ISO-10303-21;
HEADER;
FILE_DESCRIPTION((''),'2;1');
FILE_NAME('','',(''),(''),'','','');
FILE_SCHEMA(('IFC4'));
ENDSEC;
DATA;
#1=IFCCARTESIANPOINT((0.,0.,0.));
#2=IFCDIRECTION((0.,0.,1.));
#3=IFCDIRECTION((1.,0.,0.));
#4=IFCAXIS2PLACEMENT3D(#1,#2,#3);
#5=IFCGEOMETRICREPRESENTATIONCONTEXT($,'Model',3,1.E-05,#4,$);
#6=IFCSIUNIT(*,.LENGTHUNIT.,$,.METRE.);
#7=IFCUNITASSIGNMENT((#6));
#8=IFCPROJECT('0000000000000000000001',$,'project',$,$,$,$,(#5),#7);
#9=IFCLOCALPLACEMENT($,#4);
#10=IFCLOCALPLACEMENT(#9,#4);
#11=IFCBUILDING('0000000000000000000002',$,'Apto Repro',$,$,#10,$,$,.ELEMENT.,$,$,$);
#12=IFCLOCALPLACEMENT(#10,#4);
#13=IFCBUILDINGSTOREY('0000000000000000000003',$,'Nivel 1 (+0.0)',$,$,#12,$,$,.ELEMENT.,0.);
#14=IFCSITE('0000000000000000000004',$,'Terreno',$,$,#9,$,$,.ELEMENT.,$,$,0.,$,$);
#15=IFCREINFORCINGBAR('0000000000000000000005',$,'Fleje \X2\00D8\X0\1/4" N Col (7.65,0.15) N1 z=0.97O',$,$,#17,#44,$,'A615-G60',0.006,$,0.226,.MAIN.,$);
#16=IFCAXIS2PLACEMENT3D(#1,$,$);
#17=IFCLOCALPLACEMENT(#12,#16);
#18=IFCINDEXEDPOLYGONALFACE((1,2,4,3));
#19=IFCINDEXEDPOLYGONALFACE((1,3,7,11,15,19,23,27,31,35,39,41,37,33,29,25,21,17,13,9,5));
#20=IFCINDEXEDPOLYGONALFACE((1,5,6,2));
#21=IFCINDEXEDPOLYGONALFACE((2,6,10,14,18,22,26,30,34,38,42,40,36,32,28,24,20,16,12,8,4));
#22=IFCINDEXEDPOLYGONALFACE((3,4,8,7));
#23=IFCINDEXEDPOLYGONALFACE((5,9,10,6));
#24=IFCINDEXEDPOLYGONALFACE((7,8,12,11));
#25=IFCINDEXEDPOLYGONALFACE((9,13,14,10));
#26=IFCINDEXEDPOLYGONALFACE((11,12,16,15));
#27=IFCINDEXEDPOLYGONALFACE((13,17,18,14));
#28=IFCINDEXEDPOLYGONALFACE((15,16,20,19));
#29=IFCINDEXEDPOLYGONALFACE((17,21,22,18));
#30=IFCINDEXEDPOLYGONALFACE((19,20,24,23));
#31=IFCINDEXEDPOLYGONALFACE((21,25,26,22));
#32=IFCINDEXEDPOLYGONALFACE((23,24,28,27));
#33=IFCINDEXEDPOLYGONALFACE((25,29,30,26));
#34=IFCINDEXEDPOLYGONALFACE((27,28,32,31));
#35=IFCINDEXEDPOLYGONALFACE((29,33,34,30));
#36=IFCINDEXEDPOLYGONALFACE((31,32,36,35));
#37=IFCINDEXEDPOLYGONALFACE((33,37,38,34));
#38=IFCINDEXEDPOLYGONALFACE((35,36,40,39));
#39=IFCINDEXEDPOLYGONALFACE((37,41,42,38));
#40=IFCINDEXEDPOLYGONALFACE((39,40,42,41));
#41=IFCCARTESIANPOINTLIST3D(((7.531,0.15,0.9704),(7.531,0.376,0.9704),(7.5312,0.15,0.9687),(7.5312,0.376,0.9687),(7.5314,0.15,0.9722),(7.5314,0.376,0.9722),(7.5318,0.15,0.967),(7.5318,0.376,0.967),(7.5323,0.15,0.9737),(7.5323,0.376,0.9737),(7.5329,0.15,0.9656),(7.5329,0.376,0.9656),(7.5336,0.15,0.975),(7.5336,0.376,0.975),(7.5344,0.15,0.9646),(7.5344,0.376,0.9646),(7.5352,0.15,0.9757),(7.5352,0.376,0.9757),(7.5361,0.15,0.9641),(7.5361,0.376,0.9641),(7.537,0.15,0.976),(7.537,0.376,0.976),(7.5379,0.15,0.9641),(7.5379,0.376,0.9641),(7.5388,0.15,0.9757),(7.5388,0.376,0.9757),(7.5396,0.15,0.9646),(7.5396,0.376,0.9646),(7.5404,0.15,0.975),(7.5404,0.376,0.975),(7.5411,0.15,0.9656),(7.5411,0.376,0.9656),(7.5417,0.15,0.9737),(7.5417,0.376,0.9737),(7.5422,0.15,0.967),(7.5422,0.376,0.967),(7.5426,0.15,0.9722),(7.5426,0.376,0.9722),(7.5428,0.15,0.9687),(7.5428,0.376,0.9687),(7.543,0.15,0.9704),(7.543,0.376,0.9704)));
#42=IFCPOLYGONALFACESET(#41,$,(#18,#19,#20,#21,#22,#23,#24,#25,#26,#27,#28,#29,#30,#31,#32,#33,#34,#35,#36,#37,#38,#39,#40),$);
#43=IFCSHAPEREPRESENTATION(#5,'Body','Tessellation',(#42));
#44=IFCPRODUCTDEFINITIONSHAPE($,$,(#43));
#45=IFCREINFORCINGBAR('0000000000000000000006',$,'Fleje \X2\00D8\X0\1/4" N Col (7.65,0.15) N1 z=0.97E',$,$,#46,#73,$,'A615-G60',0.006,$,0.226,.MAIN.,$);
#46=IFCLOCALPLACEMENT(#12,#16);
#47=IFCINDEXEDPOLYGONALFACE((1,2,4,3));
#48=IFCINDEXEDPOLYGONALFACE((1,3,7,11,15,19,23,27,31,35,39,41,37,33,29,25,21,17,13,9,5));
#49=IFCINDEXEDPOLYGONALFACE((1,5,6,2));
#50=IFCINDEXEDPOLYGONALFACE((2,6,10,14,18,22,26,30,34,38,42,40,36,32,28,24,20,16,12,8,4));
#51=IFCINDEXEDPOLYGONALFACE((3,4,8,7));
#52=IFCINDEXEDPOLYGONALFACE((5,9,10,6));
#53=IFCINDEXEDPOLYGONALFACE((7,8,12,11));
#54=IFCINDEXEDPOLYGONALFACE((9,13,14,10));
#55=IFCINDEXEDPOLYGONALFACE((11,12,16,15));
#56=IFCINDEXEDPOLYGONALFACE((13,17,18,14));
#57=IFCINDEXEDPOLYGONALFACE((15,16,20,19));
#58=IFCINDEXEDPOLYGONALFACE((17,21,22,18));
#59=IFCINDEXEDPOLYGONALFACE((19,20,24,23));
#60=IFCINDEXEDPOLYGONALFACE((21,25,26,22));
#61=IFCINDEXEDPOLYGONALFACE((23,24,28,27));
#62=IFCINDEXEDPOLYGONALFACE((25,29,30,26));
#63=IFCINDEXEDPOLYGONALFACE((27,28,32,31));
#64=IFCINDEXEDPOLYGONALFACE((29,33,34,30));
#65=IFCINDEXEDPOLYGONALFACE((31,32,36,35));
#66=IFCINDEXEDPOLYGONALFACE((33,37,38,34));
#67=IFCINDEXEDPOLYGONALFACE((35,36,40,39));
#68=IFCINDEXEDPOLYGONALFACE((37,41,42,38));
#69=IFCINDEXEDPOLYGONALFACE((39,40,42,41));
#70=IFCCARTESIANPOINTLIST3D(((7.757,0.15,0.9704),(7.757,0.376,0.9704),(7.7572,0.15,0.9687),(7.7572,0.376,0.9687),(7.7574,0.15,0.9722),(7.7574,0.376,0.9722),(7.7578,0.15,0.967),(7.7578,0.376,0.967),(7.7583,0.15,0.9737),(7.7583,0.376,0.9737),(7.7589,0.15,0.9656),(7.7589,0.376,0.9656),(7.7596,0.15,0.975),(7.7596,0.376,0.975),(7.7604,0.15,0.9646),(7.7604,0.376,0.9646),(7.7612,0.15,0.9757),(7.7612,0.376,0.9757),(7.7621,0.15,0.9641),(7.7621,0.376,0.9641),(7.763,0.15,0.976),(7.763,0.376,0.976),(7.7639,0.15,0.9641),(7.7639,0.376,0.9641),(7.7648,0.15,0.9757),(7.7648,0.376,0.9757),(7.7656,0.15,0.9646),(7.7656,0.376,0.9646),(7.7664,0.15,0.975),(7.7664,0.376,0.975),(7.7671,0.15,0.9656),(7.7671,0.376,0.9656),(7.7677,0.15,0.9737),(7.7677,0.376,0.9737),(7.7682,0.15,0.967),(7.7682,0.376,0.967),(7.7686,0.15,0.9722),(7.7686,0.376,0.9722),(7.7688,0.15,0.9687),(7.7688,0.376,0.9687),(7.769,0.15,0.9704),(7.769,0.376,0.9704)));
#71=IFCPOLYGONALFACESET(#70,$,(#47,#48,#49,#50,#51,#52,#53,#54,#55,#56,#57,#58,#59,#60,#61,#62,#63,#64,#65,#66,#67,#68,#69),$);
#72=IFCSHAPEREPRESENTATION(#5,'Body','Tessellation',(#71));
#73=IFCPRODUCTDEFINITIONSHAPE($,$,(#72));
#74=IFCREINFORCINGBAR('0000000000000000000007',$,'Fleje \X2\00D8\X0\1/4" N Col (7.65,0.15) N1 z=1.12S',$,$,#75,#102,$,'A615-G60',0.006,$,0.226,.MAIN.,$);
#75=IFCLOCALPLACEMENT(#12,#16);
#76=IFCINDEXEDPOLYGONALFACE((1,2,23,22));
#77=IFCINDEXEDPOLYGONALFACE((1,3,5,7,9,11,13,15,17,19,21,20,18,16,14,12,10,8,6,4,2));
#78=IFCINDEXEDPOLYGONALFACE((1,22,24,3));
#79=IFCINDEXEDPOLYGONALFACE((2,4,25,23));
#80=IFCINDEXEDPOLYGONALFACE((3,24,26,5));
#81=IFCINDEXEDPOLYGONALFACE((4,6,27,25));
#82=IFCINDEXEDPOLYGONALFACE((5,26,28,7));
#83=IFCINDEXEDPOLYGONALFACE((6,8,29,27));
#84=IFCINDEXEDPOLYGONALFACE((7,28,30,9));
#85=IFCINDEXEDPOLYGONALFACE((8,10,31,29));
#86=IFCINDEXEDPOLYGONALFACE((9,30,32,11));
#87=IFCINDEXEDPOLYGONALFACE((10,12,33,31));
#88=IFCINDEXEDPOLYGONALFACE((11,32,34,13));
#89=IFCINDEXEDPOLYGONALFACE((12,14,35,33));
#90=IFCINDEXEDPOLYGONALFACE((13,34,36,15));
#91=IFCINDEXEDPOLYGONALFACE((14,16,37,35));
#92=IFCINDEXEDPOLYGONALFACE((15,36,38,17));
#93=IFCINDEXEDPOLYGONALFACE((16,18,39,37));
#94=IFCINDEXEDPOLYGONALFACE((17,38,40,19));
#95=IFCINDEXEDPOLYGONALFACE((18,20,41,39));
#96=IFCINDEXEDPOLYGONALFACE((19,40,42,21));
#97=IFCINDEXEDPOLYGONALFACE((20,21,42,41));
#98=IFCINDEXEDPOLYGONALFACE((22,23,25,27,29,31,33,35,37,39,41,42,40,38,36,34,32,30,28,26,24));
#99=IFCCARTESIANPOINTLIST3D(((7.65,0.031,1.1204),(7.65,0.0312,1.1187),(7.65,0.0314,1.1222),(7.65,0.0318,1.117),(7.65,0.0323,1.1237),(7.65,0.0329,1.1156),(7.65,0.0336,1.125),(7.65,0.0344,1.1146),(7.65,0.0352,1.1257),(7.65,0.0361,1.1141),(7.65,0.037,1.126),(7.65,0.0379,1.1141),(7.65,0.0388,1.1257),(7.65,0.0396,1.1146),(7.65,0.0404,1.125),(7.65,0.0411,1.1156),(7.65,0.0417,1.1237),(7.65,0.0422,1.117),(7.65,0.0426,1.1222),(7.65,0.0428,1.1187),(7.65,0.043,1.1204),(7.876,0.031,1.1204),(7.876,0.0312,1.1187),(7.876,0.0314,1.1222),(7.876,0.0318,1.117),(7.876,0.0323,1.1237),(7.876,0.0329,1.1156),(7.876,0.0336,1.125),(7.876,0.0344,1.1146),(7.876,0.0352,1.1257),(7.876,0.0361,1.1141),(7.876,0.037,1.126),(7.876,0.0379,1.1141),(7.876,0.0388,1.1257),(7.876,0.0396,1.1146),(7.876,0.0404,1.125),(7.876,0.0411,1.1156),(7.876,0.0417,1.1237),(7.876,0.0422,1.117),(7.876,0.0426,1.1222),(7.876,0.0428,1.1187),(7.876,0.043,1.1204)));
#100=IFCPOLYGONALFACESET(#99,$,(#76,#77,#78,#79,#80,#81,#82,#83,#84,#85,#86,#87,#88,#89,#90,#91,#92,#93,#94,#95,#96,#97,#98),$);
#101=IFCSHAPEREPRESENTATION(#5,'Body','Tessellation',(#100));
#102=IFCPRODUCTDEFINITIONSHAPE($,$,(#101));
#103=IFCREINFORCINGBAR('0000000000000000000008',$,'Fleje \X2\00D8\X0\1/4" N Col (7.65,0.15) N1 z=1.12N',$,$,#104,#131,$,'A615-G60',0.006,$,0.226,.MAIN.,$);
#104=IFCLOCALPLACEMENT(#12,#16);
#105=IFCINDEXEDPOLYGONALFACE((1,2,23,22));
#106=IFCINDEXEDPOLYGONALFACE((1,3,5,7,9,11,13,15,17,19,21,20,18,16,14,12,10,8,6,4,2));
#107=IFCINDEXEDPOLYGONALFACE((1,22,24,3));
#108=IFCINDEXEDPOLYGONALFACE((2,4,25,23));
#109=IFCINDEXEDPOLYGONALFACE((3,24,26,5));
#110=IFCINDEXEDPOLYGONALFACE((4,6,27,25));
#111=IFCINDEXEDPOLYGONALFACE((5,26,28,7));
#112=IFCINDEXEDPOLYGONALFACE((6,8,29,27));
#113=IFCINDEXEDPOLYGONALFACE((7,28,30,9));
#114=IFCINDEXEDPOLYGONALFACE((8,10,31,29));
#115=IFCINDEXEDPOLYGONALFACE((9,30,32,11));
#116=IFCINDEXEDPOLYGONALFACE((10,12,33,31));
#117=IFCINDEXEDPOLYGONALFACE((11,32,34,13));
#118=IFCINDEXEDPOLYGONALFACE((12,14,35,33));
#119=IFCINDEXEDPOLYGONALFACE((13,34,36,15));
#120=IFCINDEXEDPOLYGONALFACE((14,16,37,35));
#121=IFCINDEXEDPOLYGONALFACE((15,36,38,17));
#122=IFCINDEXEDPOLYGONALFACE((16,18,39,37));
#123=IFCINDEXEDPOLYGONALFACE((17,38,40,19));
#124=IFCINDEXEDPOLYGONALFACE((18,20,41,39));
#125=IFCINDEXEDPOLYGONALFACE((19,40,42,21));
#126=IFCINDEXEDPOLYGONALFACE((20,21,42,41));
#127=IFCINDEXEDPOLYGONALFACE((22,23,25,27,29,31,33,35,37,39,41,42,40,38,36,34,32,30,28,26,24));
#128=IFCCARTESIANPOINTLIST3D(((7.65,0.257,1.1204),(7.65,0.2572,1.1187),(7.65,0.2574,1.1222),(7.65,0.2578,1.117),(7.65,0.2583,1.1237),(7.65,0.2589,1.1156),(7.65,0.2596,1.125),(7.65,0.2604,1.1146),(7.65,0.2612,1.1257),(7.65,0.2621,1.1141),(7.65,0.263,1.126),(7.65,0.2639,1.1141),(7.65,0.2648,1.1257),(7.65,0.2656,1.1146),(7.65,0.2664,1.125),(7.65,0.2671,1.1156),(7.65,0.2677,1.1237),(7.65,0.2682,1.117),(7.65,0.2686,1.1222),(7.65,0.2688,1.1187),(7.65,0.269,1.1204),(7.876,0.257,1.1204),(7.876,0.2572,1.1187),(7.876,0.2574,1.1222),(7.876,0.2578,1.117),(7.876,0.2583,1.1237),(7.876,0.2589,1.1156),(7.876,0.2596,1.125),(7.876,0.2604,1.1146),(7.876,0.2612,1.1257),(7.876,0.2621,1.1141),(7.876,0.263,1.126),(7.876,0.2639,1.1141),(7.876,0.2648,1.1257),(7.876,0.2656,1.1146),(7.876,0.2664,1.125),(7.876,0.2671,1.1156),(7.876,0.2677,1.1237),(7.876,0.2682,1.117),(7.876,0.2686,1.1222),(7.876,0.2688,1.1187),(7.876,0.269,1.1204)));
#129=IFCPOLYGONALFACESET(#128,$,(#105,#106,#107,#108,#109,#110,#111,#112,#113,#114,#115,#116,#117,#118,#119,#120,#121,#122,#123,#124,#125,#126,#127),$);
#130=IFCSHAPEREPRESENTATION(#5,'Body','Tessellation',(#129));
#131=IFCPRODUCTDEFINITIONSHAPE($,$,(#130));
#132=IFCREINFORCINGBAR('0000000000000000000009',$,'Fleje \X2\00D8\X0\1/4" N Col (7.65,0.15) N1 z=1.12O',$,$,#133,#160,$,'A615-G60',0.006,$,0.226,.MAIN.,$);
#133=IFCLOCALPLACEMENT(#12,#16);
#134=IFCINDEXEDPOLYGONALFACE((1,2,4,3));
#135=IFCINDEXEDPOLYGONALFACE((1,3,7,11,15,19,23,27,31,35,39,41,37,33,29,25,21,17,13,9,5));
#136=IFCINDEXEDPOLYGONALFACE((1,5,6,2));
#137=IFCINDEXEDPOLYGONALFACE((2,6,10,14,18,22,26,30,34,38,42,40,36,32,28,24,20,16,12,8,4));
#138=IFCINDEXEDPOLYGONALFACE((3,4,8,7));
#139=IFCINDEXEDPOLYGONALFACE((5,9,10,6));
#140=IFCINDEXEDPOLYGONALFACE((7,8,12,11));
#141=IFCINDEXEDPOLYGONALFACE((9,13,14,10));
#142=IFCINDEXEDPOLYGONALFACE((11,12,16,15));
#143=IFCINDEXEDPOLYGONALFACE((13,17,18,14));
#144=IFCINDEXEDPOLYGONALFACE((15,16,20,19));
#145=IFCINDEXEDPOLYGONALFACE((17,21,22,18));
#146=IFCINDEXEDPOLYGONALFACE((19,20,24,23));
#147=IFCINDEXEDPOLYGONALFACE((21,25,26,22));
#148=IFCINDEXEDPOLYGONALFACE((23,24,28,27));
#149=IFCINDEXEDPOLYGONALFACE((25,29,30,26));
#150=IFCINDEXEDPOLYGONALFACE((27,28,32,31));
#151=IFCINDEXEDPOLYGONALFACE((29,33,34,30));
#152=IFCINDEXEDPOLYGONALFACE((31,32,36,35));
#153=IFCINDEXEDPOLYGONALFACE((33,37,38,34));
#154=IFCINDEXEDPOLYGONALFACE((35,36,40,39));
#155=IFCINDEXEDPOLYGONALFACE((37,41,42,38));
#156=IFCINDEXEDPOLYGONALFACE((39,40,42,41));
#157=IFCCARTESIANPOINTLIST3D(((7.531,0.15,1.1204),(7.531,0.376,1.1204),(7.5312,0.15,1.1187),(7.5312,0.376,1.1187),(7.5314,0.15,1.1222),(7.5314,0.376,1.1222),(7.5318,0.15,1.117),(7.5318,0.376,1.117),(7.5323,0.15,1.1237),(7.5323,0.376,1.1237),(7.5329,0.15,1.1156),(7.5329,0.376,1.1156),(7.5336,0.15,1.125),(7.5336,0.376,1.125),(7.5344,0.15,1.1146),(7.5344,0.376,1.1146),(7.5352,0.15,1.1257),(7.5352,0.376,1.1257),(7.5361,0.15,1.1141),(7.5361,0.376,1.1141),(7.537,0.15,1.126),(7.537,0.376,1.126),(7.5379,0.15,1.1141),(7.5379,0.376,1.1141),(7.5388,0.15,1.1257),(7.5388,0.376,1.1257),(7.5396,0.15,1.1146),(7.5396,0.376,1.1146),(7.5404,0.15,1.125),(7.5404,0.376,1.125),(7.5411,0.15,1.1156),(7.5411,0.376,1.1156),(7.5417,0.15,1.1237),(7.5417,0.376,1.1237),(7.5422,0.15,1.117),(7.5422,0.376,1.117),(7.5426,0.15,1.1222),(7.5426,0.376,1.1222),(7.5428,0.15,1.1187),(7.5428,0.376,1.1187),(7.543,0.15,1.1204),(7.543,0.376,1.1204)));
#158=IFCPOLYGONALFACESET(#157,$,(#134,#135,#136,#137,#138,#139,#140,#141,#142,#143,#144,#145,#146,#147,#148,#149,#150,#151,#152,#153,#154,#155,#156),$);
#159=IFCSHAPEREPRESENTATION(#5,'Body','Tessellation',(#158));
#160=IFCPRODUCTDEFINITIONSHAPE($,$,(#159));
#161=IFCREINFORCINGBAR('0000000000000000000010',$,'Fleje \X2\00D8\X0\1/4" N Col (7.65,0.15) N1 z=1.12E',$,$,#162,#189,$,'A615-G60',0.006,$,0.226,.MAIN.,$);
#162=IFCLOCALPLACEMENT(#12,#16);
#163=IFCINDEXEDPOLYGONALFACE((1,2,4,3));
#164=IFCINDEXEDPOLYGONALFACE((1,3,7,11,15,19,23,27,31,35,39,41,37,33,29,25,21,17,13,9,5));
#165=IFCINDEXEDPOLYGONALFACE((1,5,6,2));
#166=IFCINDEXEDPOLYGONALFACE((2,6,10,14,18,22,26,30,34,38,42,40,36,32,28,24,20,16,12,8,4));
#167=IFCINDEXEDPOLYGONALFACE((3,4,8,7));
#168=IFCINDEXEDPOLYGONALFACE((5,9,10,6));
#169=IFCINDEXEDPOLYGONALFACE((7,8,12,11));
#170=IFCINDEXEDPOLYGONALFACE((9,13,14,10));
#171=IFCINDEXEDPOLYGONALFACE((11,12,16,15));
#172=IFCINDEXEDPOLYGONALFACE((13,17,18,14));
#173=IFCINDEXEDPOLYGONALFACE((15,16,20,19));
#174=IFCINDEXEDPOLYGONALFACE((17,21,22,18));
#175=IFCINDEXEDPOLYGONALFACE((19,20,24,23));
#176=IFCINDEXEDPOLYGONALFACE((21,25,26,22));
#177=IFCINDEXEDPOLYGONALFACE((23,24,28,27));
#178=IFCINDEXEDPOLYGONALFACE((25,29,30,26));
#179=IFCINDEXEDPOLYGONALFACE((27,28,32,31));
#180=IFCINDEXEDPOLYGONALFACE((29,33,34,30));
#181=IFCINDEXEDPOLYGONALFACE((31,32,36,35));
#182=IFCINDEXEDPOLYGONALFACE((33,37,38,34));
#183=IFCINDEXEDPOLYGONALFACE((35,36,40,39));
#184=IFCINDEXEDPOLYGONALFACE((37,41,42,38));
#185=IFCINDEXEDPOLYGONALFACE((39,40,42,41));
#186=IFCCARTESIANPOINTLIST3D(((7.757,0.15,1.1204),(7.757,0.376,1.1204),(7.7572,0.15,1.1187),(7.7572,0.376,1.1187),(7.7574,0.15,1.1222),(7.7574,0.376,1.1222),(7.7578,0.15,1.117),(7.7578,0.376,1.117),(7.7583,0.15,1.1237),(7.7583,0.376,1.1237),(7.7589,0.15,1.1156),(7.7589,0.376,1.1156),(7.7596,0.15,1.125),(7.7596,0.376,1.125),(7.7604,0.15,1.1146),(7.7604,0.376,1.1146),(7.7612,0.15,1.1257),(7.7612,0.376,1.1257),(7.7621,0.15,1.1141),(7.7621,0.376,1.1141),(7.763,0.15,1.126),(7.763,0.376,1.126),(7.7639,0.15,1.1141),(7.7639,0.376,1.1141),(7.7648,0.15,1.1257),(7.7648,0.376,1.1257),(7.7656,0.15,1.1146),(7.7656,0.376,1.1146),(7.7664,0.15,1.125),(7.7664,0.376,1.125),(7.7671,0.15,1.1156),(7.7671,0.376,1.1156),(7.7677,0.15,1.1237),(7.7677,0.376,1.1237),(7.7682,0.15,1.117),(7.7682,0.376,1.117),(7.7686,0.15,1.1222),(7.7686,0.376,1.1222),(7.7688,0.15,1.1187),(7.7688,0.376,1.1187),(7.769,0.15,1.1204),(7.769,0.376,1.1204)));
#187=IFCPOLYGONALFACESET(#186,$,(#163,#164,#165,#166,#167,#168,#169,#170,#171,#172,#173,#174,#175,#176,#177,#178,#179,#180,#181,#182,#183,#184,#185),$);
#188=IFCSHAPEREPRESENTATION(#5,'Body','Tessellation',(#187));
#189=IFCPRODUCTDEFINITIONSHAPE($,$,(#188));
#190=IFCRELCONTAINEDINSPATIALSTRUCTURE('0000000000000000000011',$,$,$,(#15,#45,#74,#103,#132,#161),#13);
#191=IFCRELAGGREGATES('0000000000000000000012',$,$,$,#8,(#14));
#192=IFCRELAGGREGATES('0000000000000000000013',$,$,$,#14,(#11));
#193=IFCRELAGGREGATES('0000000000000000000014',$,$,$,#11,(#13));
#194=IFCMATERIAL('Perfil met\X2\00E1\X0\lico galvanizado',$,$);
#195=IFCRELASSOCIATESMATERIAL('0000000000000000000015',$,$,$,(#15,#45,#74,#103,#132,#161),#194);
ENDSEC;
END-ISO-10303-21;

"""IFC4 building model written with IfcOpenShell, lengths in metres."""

from ifc_helpers import new_model, si_unit, frame, origin_with_axes, origin_2d_with_axis, place, context, project, spatial, circle, extrude, material, element, save


model = new_model("IFC4")

# Units and contexts
model_context = context("Model", 3, precision=1e-05, world=origin_with_axes())
ifc_project = project(units=[si_unit("LENGTHUNIT", "METRE")], contexts=[model_context])

# Site, building, storey
site_placement = place(None, origin_with_axes())
site = spatial("IfcSite", under=ifc_project, at=site_placement, Name="Terreno", CompositionType="ELEMENT", RefElevation=0.0)
building_placement = place(site_placement, origin_with_axes())
building = spatial("IfcBuilding", under=site, at=building_placement, Name="Apto Repro", CompositionType="ELEMENT")
storey_placement = place(building_placement, origin_with_axes())
storey = spatial("IfcBuildingStorey", under=building, at=storey_placement, Name="Nivel 1 (+0.0)", CompositionType="ELEMENT", Elevation=0.0)

# Reinforcing bars
ifc_material = material(Name="Perfil metálico galvanizado")
reinforcing_bar_1_placement = place(storey_placement, origin_with_axes())
element("IfcReinforcingBar", 1, at=reinforcing_bar_1_placement, inside=storey, material=ifc_material, Name="Fleje Ø1/4\" N Col (7.65,0.15) N1 z=0.97O", SteelGrade="A615-G60", BarLength=0.226, NominalDiameter=0.006, PredefinedType="MAIN", context=model_context, shape_type="SweptSolid", body=[
    extrude(circle(Radius=0.006, at=origin_2d_with_axis()), frame((7.537, 0.15, 0.97), z_axis=(0.0, 1.0, 0.0), x_axis=(0.0, 0.0, 1.0)), (0.0, 0.0, 1.0), 0.226),
])
reinforcing_bar_2_placement = place(storey_placement, origin_with_axes())
element("IfcReinforcingBar", 2, at=reinforcing_bar_2_placement, inside=storey, material=ifc_material, Name="Fleje Ø1/4\" N Col (7.65,0.15) N1 z=0.97E", SteelGrade="A615-G60", BarLength=0.226, NominalDiameter=0.006, PredefinedType="MAIN", context=model_context, shape_type="SweptSolid", body=[
    extrude(circle(Radius=0.006, at=origin_2d_with_axis()), frame((7.763, 0.15, 0.97), z_axis=(0.0, 1.0, 0.0), x_axis=(0.0, 0.0, 1.0)), (0.0, 0.0, 1.0), 0.226),
])
reinforcing_bar_3_placement = place(storey_placement, origin_with_axes())
element("IfcReinforcingBar", 3, at=reinforcing_bar_3_placement, inside=storey, material=ifc_material, Name="Fleje Ø1/4\" N Col (7.65,0.15) N1 z=1.12S", SteelGrade="A615-G60", BarLength=0.226, NominalDiameter=0.006, PredefinedType="MAIN", context=model_context, shape_type="SweptSolid", body=[
    extrude(circle(Radius=0.006, at=origin_2d_with_axis()), frame((7.65, 0.037, 1.12), z_axis=(1.0, 0.0, 0.0), x_axis=(0.0, 0.0, 1.0)), (0.0, 0.0, 1.0), 0.226),
])
reinforcing_bar_4_placement = place(storey_placement, origin_with_axes())
element("IfcReinforcingBar", 4, at=reinforcing_bar_4_placement, inside=storey, material=ifc_material, Name="Fleje Ø1/4\" N Col (7.65,0.15) N1 z=1.12N", SteelGrade="A615-G60", BarLength=0.226, NominalDiameter=0.006, PredefinedType="MAIN", context=model_context, shape_type="SweptSolid", body=[
    extrude(circle(Radius=0.006, at=origin_2d_with_axis()), frame((7.65, 0.263, 1.12), z_axis=(1.0, 0.0, 0.0), x_axis=(0.0, 0.0, 1.0)), (0.0, 0.0, 1.0), 0.226),
])
reinforcing_bar_5_placement = place(storey_placement, origin_with_axes())
element("IfcReinforcingBar", 5, at=reinforcing_bar_5_placement, inside=storey, material=ifc_material, Name="Fleje Ø1/4\" N Col (7.65,0.15) N1 z=1.12O", SteelGrade="A615-G60", BarLength=0.226, NominalDiameter=0.006, PredefinedType="MAIN", context=model_context, shape_type="SweptSolid", body=[
    extrude(circle(Radius=0.006, at=origin_2d_with_axis()), frame((7.537, 0.15, 1.12), z_axis=(0.0, 1.0, 0.0), x_axis=(0.0, 0.0, 1.0)), (0.0, 0.0, 1.0), 0.226),
])
reinforcing_bar_6_placement = place(storey_placement, origin_with_axes())
element("IfcReinforcingBar", 6, at=reinforcing_bar_6_placement, inside=storey, material=ifc_material, Name="Fleje Ø1/4\" N Col (7.65,0.15) N1 z=1.12E", SteelGrade="A615-G60", BarLength=0.226, NominalDiameter=0.006, PredefinedType="MAIN", context=model_context, shape_type="SweptSolid", body=[
    extrude(circle(Radius=0.006, at=origin_2d_with_axis()), frame((7.763, 0.15, 1.12), z_axis=(0.0, 1.0, 0.0), x_axis=(0.0, 0.0, 1.0)), (0.0, 0.0, 1.0), 0.226),
])

save(model, "model.ifc")
